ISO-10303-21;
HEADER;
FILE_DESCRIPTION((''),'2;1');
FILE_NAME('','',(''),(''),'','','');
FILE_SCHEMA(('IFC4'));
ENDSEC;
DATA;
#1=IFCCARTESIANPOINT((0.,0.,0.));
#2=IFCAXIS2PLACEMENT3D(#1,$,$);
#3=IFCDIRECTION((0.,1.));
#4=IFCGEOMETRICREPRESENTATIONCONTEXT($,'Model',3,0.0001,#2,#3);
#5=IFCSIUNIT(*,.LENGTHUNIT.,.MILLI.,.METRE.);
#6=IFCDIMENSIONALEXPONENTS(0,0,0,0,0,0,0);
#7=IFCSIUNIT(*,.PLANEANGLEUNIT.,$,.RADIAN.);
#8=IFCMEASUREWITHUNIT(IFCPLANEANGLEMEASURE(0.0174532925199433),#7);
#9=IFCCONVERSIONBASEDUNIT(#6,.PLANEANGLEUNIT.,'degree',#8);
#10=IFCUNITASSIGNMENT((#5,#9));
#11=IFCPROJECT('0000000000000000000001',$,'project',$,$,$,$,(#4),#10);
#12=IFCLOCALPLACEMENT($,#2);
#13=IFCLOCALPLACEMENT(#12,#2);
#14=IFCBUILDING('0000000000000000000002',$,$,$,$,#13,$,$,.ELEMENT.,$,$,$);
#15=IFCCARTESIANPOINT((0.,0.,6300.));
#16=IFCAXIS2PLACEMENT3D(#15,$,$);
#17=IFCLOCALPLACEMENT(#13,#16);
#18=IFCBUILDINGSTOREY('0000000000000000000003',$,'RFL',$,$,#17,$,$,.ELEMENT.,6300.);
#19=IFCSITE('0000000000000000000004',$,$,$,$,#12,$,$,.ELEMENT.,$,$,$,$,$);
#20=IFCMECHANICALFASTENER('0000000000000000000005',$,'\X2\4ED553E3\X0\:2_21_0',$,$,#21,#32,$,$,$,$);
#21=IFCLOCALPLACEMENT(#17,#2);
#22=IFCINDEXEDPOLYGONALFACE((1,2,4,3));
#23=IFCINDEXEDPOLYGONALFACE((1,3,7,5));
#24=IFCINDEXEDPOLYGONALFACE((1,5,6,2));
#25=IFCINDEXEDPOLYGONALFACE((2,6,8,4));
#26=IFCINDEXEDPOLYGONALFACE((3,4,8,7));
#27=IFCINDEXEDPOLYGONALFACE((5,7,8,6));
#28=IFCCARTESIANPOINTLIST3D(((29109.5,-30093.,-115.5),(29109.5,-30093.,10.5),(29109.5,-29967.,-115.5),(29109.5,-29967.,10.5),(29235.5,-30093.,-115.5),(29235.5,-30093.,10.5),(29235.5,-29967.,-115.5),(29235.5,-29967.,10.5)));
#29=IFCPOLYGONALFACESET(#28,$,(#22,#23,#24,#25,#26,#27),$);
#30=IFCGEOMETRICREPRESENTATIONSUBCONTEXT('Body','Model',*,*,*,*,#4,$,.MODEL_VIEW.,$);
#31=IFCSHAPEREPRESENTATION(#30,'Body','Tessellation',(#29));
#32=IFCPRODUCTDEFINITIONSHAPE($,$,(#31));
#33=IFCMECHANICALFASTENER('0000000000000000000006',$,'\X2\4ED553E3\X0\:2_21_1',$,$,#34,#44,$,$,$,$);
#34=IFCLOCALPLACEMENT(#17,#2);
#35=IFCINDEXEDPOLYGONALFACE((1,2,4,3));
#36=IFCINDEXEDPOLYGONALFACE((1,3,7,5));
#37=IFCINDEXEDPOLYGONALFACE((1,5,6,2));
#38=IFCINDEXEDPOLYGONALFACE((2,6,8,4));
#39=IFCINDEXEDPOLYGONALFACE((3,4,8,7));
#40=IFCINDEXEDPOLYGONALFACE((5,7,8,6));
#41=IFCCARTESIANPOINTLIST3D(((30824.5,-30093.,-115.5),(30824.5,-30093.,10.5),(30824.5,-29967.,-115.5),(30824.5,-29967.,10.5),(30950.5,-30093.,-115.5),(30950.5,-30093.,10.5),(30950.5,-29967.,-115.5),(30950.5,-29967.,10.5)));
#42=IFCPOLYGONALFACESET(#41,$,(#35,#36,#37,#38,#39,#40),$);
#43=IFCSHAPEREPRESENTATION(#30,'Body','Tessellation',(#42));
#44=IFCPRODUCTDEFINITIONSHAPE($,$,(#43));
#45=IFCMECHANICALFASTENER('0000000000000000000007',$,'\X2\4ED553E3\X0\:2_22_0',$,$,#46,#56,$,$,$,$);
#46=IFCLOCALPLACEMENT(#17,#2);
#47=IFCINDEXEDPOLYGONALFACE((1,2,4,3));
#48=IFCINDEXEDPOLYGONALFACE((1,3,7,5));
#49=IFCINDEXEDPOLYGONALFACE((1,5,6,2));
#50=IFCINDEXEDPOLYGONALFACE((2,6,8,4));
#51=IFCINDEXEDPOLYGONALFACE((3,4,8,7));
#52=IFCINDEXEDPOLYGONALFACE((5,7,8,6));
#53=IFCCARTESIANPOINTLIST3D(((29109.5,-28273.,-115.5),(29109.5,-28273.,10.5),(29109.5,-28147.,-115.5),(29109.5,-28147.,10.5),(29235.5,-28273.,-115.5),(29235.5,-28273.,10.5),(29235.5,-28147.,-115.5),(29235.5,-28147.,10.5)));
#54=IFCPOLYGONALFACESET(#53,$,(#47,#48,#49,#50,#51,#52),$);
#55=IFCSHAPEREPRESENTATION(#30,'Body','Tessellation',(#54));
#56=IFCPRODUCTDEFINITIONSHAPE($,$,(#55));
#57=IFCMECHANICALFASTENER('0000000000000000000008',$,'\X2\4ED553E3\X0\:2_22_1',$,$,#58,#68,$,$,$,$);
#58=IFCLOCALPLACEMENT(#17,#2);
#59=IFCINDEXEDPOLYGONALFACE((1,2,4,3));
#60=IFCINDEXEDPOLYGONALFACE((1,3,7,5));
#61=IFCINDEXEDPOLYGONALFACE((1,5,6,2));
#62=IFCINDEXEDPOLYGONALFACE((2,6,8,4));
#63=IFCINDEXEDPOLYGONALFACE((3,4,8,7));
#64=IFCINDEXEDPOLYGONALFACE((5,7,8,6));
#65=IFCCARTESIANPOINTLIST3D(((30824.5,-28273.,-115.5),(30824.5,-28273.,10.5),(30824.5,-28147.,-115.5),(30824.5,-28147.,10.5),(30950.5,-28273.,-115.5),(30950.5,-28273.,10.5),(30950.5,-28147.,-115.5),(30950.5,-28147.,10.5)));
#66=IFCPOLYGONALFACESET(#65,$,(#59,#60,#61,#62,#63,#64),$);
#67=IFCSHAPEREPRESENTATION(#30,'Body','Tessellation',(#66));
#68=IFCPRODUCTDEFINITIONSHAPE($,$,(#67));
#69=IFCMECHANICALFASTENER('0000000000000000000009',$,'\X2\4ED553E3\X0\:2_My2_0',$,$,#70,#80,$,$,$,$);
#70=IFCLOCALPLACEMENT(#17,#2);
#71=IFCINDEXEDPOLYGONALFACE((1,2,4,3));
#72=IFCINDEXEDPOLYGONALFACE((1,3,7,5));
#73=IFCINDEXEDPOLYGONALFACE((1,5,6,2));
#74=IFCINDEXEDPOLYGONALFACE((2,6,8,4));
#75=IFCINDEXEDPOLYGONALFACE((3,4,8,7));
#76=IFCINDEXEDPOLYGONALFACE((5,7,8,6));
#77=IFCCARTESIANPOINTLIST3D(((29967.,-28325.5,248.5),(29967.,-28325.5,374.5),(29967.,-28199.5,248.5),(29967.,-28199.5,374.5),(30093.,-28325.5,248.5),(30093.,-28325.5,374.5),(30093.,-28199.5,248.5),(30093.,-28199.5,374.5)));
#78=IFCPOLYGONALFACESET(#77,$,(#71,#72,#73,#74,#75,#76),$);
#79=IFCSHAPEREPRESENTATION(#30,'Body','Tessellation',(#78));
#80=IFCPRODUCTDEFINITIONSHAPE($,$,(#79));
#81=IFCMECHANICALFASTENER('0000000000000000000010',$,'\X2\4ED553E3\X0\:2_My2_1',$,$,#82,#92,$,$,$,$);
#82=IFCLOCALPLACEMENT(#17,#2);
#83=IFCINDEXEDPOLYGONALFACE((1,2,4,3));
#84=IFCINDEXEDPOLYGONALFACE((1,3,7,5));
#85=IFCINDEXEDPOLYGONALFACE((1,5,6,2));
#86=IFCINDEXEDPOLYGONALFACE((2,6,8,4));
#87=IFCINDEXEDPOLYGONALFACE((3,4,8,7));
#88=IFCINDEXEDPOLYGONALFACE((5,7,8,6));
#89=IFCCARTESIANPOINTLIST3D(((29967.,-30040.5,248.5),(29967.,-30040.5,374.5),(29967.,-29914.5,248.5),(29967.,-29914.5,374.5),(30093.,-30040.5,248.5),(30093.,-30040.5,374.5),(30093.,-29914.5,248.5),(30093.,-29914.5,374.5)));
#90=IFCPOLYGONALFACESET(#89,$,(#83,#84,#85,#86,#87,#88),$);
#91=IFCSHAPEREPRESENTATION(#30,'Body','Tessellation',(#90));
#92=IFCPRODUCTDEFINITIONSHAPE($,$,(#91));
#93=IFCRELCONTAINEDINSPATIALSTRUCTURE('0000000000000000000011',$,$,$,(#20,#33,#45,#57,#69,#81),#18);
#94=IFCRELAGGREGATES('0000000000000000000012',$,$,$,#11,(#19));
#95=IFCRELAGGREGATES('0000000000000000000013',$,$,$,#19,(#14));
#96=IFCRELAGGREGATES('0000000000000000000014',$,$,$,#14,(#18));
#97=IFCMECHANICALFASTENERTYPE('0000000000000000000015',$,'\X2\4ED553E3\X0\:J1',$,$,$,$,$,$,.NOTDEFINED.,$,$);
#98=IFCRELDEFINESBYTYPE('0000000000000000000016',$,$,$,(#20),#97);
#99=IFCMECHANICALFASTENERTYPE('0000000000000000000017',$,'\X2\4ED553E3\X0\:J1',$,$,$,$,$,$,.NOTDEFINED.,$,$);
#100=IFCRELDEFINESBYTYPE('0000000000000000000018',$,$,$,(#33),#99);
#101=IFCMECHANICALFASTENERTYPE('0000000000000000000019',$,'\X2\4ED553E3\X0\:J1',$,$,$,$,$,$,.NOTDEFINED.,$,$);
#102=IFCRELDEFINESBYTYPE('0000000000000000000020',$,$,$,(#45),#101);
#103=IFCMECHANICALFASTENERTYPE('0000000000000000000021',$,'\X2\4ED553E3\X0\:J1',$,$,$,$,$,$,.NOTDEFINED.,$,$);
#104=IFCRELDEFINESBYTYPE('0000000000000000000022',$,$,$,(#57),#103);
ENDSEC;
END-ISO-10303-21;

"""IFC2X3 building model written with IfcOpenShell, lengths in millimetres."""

from ifc_helpers import new_model, entity, si_unit, converted_unit, direction, frame, origin, origin_with_axes, origin_2d, place, context, subcontext, project, spatial, rectangle, extrude, type_object, element, save


model = new_model("IFC2X3")

# Units and contexts
model_context = context("Model", 3, precision=0.0001, world=origin(), true_north=direction((0.0, 1.0)))
body_context = subcontext(model_context, "Body", "Model", "MODEL_VIEW")
ifc_project = project(units=[si_unit("LENGTHUNIT", "METRE", prefix="MILLI"), converted_unit("PLANEANGLEUNIT", "degree", entity("IfcPlaneAngleMeasure", 0.0174532925199433), si_unit("PLANEANGLEUNIT", "RADIAN"), dimensions=[0, 0, 0, 0, 0, 0, 0])], contexts=[model_context])

# Site, building, storey
site_placement = place(None, origin())
site = spatial("IfcSite", under=ifc_project, at=site_placement, CompositionType="ELEMENT")
building_placement = place(site_placement, origin())
building = spatial("IfcBuilding", under=site, at=building_placement, CompositionType="ELEMENT")
storey_placement = place(building_placement, frame((0.0, 0.0, 6300.0)))
storey = spatial("IfcBuildingStorey", under=building, at=storey_placement, Name="RFL", CompositionType="ELEMENT", Elevation=6300.0)

# Mechanical fasteners
mechanical_fastener_type_1 = type_object("IfcMechanicalFastenerType", Name="仕口:J1")
mechanical_fastener_1_placement = place(storey_placement, frame((29172.5, -30030.0, -115.5)))
element("IfcMechanicalFastener", 1, at=mechanical_fastener_1_placement, inside=storey, type_object=mechanical_fastener_type_1, Name="仕口:2_21_0", context=body_context, shape_type="SweptSolid", body=[
    extrude(rectangle(XDim=126.0, YDim=126.0, at=origin_2d()), origin_with_axes(), (0.0, 0.0, 1.0), 126.0),
])
mechanical_fastener_type_2 = type_object("IfcMechanicalFastenerType", Name="仕口:J1")
mechanical_fastener_2_placement = place(storey_placement, frame((30887.5, -30030.0, -115.5)))
element("IfcMechanicalFastener", 2, at=mechanical_fastener_2_placement, inside=storey, type_object=mechanical_fastener_type_2, Name="仕口:2_21_1", context=body_context, shape_type="SweptSolid", body=[
    extrude(rectangle(XDim=126.0, YDim=126.0, at=origin_2d()), origin_with_axes(), (0.0, 0.0, 1.0), 126.0),
])
mechanical_fastener_type_3 = type_object("IfcMechanicalFastenerType", Name="仕口:J1")
mechanical_fastener_3_placement = place(storey_placement, frame((29172.5, -28210.0, -115.5)))
element("IfcMechanicalFastener", 3, at=mechanical_fastener_3_placement, inside=storey, type_object=mechanical_fastener_type_3, Name="仕口:2_22_0", context=body_context, shape_type="SweptSolid", body=[
    extrude(rectangle(XDim=126.0, YDim=126.0, at=origin_2d()), origin_with_axes(), (0.0, 0.0, 1.0), 126.0),
])
mechanical_fastener_type_4 = type_object("IfcMechanicalFastenerType", Name="仕口:J1")
mechanical_fastener_4_placement = place(storey_placement, frame((30887.5, -28210.0, -115.5)))
element("IfcMechanicalFastener", 4, at=mechanical_fastener_4_placement, inside=storey, type_object=mechanical_fastener_type_4, Name="仕口:2_22_1", context=body_context, shape_type="SweptSolid", body=[
    extrude(rectangle(XDim=126.0, YDim=126.0, at=origin_2d()), origin_with_axes(), (0.0, 0.0, 1.0), 126.0),
])
for number, where, name in (
    (5, (30030.0, -28262.5, 248.5), "仕口:2_My2_0"),
    (6, (30030.0, -29977.5, 248.5), "仕口:2_My2_1"),
):
    element("IfcMechanicalFastener", number, at=place(storey_placement, frame(where)), inside=storey, Name=name, context=body_context, shape_type="SweptSolid", body=[
        extrude(rectangle(XDim=126.0, YDim=126.0, at=origin_2d()), origin_with_axes(), (0.0, 0.0, 1.0), 126.0),
    ])

save(model, "model.ifc")
